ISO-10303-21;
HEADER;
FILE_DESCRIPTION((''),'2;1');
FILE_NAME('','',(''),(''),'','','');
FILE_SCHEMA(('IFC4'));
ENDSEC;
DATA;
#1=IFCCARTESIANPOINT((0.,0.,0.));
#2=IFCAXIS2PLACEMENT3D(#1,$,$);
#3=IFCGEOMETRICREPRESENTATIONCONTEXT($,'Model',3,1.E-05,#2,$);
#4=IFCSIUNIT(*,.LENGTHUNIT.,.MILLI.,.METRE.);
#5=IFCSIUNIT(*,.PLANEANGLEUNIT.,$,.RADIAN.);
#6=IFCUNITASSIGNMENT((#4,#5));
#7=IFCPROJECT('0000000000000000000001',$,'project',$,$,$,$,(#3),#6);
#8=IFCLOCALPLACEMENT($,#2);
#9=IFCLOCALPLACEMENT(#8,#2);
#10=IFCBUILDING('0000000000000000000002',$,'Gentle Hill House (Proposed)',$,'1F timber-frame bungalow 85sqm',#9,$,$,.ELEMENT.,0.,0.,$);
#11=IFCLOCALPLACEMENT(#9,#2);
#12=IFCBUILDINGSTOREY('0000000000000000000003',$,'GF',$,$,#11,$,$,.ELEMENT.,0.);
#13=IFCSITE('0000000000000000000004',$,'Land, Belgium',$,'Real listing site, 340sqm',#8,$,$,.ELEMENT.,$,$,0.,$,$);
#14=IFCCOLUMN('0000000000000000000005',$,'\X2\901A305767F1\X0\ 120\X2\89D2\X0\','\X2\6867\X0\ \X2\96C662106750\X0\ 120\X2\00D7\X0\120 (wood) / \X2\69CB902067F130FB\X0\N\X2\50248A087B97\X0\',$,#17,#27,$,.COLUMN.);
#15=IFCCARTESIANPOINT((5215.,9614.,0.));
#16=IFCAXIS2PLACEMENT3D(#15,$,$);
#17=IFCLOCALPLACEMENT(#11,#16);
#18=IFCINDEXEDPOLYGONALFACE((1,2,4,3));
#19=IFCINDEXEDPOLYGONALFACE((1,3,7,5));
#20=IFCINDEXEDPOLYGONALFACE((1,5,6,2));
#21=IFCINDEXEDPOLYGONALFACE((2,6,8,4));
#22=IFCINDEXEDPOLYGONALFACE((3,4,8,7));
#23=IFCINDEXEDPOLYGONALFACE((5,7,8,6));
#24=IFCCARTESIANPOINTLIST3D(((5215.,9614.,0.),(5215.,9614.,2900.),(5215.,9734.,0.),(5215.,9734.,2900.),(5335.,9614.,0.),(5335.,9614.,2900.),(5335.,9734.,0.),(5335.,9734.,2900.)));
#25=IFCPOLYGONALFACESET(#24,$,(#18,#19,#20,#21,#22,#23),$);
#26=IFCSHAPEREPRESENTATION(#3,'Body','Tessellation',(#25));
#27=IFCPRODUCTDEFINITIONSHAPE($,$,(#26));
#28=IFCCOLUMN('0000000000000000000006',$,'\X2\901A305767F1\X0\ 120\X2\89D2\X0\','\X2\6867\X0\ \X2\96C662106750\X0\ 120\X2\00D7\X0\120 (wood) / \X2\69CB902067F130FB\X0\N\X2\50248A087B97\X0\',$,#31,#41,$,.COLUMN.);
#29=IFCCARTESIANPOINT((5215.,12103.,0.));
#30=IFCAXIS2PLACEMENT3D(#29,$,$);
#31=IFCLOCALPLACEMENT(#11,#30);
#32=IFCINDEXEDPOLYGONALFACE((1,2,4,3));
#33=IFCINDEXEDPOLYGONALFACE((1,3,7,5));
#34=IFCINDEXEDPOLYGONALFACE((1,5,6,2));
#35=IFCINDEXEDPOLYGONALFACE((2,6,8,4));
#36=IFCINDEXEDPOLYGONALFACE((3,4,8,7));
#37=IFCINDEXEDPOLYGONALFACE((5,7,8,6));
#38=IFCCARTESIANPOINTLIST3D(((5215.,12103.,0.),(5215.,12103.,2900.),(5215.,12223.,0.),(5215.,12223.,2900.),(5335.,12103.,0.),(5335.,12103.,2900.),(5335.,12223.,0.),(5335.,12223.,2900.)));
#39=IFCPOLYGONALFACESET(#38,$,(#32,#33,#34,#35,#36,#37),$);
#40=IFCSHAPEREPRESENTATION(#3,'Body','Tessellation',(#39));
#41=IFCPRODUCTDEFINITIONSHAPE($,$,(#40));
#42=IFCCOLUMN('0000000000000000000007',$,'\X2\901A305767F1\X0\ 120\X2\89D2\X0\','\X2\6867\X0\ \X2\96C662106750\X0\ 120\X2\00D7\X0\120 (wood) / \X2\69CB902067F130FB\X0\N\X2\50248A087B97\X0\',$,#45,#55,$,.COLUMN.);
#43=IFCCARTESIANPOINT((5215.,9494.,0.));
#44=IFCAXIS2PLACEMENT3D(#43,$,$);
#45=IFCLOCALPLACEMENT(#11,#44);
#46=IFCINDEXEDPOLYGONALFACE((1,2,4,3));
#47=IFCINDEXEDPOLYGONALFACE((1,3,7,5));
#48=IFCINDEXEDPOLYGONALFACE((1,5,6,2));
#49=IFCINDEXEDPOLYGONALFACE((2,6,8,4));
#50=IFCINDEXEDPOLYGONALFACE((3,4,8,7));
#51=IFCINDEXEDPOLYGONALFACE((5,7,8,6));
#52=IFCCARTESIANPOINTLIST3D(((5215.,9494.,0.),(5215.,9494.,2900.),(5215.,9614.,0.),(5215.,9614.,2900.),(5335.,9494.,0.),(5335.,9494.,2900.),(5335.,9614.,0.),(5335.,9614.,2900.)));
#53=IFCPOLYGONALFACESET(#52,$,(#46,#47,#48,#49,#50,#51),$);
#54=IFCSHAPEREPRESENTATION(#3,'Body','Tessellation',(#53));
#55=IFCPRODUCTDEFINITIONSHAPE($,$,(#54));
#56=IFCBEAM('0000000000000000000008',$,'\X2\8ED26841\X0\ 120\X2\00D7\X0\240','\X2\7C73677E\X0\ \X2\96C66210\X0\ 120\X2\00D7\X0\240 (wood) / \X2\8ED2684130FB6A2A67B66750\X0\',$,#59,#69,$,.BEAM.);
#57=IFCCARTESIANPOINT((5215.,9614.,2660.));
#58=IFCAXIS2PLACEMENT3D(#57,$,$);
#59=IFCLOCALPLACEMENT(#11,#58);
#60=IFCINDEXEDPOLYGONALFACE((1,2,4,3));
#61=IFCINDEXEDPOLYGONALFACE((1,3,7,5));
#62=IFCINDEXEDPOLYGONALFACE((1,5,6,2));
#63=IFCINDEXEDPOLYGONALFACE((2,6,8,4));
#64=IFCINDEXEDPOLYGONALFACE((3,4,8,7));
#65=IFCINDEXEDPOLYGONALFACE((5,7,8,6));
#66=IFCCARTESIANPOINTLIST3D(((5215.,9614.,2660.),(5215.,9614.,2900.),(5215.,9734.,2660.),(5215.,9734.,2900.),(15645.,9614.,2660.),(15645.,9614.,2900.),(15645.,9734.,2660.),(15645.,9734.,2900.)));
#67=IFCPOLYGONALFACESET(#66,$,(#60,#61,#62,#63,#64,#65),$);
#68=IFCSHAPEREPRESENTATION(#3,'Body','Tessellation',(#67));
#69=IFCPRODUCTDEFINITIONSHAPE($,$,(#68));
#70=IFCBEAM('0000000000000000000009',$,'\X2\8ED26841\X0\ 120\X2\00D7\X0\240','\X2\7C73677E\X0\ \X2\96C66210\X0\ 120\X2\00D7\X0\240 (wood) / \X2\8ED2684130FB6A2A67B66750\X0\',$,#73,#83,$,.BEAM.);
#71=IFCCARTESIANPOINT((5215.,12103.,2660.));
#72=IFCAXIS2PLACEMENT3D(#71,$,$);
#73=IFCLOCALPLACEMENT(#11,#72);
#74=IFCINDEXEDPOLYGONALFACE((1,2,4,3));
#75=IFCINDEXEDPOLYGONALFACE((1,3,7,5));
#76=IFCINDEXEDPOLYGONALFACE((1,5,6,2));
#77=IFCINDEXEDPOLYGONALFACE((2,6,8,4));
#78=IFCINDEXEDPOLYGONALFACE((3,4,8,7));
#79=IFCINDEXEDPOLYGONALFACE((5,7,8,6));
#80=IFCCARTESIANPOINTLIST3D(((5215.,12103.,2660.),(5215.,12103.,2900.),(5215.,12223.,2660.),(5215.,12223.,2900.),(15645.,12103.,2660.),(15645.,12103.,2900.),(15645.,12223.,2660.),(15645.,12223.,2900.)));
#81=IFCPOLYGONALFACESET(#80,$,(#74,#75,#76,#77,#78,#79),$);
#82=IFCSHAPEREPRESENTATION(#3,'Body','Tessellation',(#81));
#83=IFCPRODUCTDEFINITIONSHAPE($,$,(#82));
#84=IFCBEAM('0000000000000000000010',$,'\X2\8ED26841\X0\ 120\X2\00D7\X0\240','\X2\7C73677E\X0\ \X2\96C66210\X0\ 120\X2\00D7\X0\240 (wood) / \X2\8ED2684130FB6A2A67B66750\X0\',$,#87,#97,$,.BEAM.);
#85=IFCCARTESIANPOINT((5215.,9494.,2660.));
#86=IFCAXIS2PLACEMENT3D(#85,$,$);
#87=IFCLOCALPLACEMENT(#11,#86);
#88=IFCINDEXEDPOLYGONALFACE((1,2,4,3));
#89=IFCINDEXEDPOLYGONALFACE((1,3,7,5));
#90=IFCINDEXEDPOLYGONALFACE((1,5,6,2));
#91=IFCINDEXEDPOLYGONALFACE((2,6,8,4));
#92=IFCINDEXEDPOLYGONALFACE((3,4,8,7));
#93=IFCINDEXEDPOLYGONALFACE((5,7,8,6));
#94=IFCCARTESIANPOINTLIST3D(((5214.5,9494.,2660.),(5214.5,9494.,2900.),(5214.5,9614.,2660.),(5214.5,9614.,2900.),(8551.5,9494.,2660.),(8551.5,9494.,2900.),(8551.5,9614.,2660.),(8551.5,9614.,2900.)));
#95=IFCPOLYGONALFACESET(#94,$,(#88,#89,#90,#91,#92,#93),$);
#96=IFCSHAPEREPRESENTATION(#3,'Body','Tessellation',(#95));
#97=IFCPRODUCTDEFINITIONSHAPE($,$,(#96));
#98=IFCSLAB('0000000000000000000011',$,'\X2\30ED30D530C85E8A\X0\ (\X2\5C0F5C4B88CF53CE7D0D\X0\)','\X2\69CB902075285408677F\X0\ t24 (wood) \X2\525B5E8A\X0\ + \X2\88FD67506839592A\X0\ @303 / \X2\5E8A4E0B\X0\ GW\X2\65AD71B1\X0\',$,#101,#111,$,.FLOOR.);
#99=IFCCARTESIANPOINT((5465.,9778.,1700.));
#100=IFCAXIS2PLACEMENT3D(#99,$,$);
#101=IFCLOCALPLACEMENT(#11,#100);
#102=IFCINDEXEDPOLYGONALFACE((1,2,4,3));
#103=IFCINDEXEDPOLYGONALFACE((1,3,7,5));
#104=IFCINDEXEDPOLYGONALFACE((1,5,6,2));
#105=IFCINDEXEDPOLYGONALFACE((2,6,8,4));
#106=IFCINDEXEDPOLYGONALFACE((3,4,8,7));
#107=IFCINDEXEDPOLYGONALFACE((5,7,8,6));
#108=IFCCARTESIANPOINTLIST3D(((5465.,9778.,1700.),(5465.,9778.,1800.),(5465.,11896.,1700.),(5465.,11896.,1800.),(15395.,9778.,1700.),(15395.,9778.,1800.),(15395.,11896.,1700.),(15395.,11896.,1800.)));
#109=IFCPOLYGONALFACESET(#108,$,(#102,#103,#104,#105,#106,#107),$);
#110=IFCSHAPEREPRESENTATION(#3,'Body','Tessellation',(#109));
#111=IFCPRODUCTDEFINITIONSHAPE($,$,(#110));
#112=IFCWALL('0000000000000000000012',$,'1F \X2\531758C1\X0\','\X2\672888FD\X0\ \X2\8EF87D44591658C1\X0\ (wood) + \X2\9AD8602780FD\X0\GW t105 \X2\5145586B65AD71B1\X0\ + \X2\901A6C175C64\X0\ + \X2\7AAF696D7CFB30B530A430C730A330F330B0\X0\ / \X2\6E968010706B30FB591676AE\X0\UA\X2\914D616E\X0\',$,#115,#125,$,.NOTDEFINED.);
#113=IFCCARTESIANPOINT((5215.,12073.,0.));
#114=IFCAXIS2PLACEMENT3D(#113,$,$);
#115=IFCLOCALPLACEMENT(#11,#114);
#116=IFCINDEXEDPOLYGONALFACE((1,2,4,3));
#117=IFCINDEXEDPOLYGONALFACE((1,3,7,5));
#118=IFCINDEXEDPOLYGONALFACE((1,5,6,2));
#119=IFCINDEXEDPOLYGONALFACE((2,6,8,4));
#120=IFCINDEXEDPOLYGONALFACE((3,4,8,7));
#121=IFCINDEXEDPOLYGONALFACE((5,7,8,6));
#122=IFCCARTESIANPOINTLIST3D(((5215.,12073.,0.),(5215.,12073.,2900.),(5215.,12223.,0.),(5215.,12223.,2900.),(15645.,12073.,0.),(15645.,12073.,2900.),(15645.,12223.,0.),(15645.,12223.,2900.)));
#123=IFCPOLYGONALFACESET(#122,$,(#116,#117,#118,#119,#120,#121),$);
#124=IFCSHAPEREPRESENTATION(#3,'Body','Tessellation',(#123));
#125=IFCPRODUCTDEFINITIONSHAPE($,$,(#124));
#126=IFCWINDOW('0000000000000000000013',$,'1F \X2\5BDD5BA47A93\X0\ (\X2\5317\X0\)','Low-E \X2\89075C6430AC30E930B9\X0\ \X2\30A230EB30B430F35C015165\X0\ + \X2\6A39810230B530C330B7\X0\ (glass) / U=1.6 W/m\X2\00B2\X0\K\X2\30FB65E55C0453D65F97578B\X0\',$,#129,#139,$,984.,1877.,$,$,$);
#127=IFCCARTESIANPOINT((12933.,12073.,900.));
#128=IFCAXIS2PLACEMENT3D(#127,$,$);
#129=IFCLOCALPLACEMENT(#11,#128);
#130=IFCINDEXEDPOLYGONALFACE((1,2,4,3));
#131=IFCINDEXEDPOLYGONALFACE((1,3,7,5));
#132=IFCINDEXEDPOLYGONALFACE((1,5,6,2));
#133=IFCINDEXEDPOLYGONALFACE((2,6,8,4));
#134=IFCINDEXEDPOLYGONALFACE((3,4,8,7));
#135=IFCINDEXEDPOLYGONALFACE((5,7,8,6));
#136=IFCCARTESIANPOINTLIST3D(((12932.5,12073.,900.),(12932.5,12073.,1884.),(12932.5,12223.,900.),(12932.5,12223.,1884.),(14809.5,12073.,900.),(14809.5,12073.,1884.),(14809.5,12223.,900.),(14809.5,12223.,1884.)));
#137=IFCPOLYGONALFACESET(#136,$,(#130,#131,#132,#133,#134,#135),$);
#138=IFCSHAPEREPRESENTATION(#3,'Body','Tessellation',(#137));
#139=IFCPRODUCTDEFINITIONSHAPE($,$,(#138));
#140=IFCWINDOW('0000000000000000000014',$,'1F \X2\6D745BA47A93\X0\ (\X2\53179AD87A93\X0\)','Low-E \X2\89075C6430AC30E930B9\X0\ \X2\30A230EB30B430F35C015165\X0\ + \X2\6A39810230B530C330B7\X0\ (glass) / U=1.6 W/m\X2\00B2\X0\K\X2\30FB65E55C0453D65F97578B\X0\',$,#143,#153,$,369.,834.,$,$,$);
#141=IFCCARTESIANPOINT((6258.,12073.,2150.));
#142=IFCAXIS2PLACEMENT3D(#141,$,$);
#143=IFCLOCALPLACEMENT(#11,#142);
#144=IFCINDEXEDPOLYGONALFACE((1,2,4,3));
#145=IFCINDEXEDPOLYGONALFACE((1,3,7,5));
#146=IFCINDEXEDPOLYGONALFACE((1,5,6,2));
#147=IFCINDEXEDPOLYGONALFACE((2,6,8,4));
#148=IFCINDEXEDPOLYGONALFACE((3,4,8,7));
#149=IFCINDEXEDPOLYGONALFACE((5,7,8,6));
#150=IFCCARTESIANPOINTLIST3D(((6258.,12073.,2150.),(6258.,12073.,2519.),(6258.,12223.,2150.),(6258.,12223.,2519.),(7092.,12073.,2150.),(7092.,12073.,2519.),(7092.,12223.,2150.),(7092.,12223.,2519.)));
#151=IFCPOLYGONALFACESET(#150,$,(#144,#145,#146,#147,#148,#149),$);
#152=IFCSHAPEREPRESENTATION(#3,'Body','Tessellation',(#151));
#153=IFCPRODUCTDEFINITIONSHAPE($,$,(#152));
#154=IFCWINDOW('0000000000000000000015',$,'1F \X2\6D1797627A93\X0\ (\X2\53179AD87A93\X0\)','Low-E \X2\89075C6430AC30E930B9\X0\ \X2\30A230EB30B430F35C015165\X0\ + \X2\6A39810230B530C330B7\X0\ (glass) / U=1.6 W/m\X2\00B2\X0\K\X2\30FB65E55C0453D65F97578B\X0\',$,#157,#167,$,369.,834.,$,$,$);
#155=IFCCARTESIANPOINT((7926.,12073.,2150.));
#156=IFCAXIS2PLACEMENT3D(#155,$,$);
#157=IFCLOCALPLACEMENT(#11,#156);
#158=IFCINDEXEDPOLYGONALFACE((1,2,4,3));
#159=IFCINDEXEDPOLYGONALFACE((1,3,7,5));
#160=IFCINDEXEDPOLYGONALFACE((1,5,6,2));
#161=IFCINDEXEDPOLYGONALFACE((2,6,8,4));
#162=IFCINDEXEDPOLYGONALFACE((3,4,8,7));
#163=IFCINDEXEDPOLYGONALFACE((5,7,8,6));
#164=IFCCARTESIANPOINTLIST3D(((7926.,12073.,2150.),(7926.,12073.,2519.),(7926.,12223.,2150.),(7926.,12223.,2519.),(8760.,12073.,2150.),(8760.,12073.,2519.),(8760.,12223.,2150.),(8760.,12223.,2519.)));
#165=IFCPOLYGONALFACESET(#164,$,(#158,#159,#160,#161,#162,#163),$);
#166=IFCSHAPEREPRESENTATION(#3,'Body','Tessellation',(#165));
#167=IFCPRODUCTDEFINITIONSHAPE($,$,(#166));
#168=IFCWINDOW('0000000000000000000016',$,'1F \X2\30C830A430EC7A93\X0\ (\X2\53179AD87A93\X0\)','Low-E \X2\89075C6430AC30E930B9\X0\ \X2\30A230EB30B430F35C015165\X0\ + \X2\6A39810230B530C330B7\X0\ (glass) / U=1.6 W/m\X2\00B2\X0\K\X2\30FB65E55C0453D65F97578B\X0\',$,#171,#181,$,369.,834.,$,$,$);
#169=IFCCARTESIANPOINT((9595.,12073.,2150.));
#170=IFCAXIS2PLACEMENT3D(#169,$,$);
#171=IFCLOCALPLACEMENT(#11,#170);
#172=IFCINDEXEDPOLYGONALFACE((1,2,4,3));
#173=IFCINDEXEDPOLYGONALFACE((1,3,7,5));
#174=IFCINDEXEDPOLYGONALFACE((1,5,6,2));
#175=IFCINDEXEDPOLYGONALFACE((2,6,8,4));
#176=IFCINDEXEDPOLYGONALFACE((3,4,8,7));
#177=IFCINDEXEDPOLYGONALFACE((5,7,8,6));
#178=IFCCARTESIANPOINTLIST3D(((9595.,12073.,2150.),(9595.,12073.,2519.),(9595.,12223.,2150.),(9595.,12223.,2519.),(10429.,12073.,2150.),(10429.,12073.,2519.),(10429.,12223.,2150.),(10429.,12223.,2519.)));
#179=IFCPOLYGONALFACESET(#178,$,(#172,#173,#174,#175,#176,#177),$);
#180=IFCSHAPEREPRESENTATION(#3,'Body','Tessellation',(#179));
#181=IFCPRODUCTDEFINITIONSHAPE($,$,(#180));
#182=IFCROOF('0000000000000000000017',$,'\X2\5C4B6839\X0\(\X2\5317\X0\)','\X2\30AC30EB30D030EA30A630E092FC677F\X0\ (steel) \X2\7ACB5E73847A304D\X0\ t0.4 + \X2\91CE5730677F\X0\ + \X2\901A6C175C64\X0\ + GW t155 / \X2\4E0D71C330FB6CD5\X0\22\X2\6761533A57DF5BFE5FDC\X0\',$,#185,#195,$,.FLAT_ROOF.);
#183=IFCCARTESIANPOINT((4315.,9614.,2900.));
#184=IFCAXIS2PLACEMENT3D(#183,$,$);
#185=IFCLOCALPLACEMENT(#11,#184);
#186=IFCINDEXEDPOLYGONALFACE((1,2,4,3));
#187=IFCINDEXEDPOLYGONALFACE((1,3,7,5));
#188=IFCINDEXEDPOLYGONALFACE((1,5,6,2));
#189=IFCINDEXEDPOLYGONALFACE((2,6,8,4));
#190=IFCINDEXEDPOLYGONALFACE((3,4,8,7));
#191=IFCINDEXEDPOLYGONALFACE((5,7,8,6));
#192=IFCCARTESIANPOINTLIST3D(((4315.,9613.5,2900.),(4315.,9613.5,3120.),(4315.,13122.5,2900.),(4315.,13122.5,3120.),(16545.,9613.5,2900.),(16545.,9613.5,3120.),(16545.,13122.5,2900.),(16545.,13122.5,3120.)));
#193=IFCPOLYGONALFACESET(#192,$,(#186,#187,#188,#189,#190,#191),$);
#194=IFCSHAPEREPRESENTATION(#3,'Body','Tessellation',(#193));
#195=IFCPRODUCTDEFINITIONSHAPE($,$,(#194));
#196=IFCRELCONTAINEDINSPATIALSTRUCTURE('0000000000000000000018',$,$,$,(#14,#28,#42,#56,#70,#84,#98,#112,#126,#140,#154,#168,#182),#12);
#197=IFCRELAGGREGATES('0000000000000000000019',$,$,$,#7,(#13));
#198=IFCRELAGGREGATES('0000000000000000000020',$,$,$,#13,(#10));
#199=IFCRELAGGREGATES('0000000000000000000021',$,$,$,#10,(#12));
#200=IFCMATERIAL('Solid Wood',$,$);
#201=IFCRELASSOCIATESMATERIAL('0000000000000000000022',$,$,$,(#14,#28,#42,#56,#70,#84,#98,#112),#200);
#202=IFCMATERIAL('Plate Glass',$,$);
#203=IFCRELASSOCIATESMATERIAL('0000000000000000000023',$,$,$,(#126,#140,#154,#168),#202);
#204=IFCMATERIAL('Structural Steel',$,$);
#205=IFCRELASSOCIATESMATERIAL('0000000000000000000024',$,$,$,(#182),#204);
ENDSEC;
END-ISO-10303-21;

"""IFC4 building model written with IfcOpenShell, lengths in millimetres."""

from ifc_helpers import new_model, si_unit, frame, frame_2d, origin, place, context, project, spatial, rectangle, extrude, material, element, fill, save


model = new_model("IFC4")

# Units and contexts
model_context = context("Model", 3, precision=1e-05, world=origin())
ifc_project = project(units=[si_unit("LENGTHUNIT", "METRE", prefix="MILLI"), si_unit("PLANEANGLEUNIT", "RADIAN")], contexts=[model_context])

# Site, building, storey
site_placement = place(None, origin())
site = spatial("IfcSite", under=ifc_project, at=site_placement, Name="Land, Belgium", ObjectType="Real listing site, 340sqm", CompositionType="ELEMENT", RefElevation=0.0)
building_placement = place(site_placement, origin())
building = spatial("IfcBuilding", under=site, at=building_placement, Name="Gentle Hill House (Proposed)", ObjectType="1F timber-frame bungalow 85sqm", CompositionType="ELEMENT", ElevationOfRefHeight=0.0, ElevationOfTerrain=0.0)
storey_placement = place(building_placement, origin())
storey = spatial("IfcBuildingStorey", under=building, at=storey_placement, Name="GF", CompositionType="ELEMENT", Elevation=0.0)

# Columns
ifc_material_1 = material(Name="Solid Wood")
column_1_placement = place(storey_placement, frame((5215.0, 9614.0, 0.0)))
element("IfcColumn", 1, at=column_1_placement, inside=storey, material=ifc_material_1, Name="通し柱 120角", Description="桧 集成材 120×120 (wood) / 構造柱・N値計算", PredefinedType="COLUMN", context=model_context, shape_type="SweptSolid", body=[
    extrude(rectangle(XDim=120.0, YDim=120.0, at=frame_2d((60.0, 60.0))), frame((5215.0, 9614.0, 0.0)), (0.0, 0.0, 1.0), 2900.0),
])
column_2_placement = place(storey_placement, frame((5215.0, 12103.0, 0.0)))
element("IfcColumn", 2, at=column_2_placement, inside=storey, material=ifc_material_1, Name="通し柱 120角", Description="桧 集成材 120×120 (wood) / 構造柱・N値計算", PredefinedType="COLUMN", context=model_context, shape_type="SweptSolid", body=[
    extrude(rectangle(XDim=120.0, YDim=120.0, at=frame_2d((60.0, 60.0))), frame((5215.0, 12103.0, 0.0)), (0.0, 0.0, 1.0), 2900.0),
])
column_3_placement = place(storey_placement, frame((5215.0, 9494.0, 0.0)))
element("IfcColumn", 3, at=column_3_placement, inside=storey, material=ifc_material_1, Name="通し柱 120角", Description="桧 集成材 120×120 (wood) / 構造柱・N値計算", PredefinedType="COLUMN", context=model_context, shape_type="SweptSolid", body=[
    extrude(rectangle(XDim=120.0, YDim=120.0, at=frame_2d((60.0, 60.0))), frame((5215.0, 9494.0, 0.0)), (0.0, 0.0, 1.0), 2900.0),
])

# Beams
beam_1_placement = place(storey_placement, frame((5215.0, 9614.0, 2660.0)))
element("IfcBeam", 4, at=beam_1_placement, inside=storey, material=ifc_material_1, Name="軒桁 120×240", Description="米松 集成 120×240 (wood) / 軒桁・横架材", PredefinedType="BEAM", context=model_context, shape_type="SweptSolid", body=[
    extrude(rectangle(XDim=10430.0, YDim=120.0, at=frame_2d((5215.0, 60.0))), frame((5215.0, 9614.0, 2660.0)), (0.0, 0.0, 1.0), 240.0),
])
beam_2_placement = place(storey_placement, frame((5215.0, 12103.0, 2660.0)))
element("IfcBeam", 5, at=beam_2_placement, inside=storey, material=ifc_material_1, Name="軒桁 120×240", Description="米松 集成 120×240 (wood) / 軒桁・横架材", PredefinedType="BEAM", context=model_context, shape_type="SweptSolid", body=[
    extrude(rectangle(XDim=10430.0, YDim=120.0, at=frame_2d((5215.0, 60.0))), frame((5215.0, 12103.0, 2660.0)), (0.0, 0.0, 1.0), 240.0),
])
beam_3_placement = place(storey_placement, frame((5215.0, 9494.0, 2660.0)))
element("IfcBeam", 6, at=beam_3_placement, inside=storey, material=ifc_material_1, Name="軒桁 120×240", Description="米松 集成 120×240 (wood) / 軒桁・横架材", PredefinedType="BEAM", context=model_context, shape_type="SweptSolid", body=[
    extrude(rectangle(XDim=3337.0, YDim=120.0, at=frame_2d((1668.0, 60.0))), frame((5215.0, 9494.0, 2660.0)), (0.0, 0.0, 1.0), 240.0),
])

# Slab
slab_1_placement = place(storey_placement, frame((5465.0, 9778.0, 1700.0)))
element("IfcSlab", 7, at=slab_1_placement, inside=storey, material=ifc_material_1, Name="ロフト床 (小屋裏収納)", Description="構造用合板 t24 (wood) 剛床 + 製材根太 @303 / 床下 GW断熱", PredefinedType="FLOOR", context=model_context, shape_type="SweptSolid", body=[
    extrude(rectangle(XDim=9930.0, YDim=2118.0, at=frame_2d((4965.0, 1059.0))), frame((5465.0, 9778.0, 1700.0)), (0.0, 0.0, 1.0), 100.0),
])

# Wall, openings, windows
wall_1_placement = place(storey_placement, frame((5215.0, 12073.0, 0.0)))
wall_1 = element("IfcWall", 8, at=wall_1_placement, inside=storey, material=ifc_material_1, Name="1F 北壁", Description="木製 軸組外壁 (wood) + 高性能GW t105 充填断熱 + 通気層 + 窯業系サイディング / 準耐火・外皮UA配慮", PredefinedType="NOTDEFINED", context=model_context, shape_type="SweptSolid", body=[
    extrude(rectangle(XDim=10430.0, YDim=150.0, at=frame_2d((5215.0, 75.0))), frame((5215.0, 12073.0, 0.0)), (0.0, 0.0, 1.0), 2900.0),
])
opening_1_placement = place(storey_placement, frame((12933.0, 12073.0, 900.0)))
opening_1 = element("IfcOpeningElement", 9, at=opening_1_placement, cuts=wall_1, PredefinedType="NOTDEFINED", context=model_context, shape_type="SweptSolid", body=[
    extrude(rectangle(XDim=1877.0, YDim=150.0, at=frame_2d((938.0, 75.0))), frame((12933.0, 12073.0, 900.0)), (0.0, 0.0, 1.0), 984.0),
])
opening_2_placement = place(storey_placement, frame((6258.0, 12073.0, 2150.0)))
opening_2 = element("IfcOpeningElement", 10, at=opening_2_placement, cuts=wall_1, PredefinedType="NOTDEFINED", context=model_context, shape_type="SweptSolid", body=[
    extrude(rectangle(XDim=834.0, YDim=150.0, at=frame_2d((417.0, 75.0))), frame((6258.0, 12073.0, 2150.0)), (0.0, 0.0, 1.0), 369.0),
])
opening_3_placement = place(storey_placement, frame((7926.0, 12073.0, 2150.0)))
opening_3 = element("IfcOpeningElement", 11, at=opening_3_placement, cuts=wall_1, PredefinedType="NOTDEFINED", context=model_context, shape_type="SweptSolid", body=[
    extrude(rectangle(XDim=834.0, YDim=150.0, at=frame_2d((417.0, 75.0))), frame((7926.0, 12073.0, 2150.0)), (0.0, 0.0, 1.0), 369.0),
])
opening_4_placement = place(storey_placement, frame((9595.0, 12073.0, 2150.0)))
opening_4 = element("IfcOpeningElement", 12, at=opening_4_placement, cuts=wall_1, PredefinedType="NOTDEFINED", context=model_context, shape_type="SweptSolid", body=[
    extrude(rectangle(XDim=834.0, YDim=150.0, at=frame_2d((417.0, 75.0))), frame((9595.0, 12073.0, 2150.0)), (0.0, 0.0, 1.0), 369.0),
])
ifc_material_2 = material(Name="Plate Glass")
window_1_placement = place(storey_placement, frame((12933.0, 12073.0, 900.0)))
window_1 = element("IfcWindow", 13, at=window_1_placement, inside=storey, material=ifc_material_2, Name="1F 寝室窓 (北)", Description="Low-E 複層ガラス アルゴン封入 + 樹脂サッシ (glass) / U=1.6 W/m²K・日射取得型", OverallHeight=984.0, OverallWidth=1877.0, context=model_context, shape_type="SweptSolid", body=[
    extrude(rectangle(XDim=1877.0, YDim=150.0, at=frame_2d((938.0, 75.0))), frame((12933.0, 12073.0, 900.0)), (0.0, 0.0, 1.0), 984.0),
])
fill(opening_1, window_1)
window_2_placement = place(storey_placement, frame((6258.0, 12073.0, 2150.0)))
window_2 = element("IfcWindow", 14, at=window_2_placement, inside=storey, material=ifc_material_2, Name="1F 浴室窓 (北高窓)", Description="Low-E 複層ガラス アルゴン封入 + 樹脂サッシ (glass) / U=1.6 W/m²K・日射取得型", OverallHeight=369.0, OverallWidth=834.0, context=model_context, shape_type="SweptSolid", body=[
    extrude(rectangle(XDim=834.0, YDim=150.0, at=frame_2d((417.0, 75.0))), frame((6258.0, 12073.0, 2150.0)), (0.0, 0.0, 1.0), 369.0),
])
fill(opening_2, window_2)
window_3_placement = place(storey_placement, frame((7926.0, 12073.0, 2150.0)))
window_3 = element("IfcWindow", 15, at=window_3_placement, inside=storey, material=ifc_material_2, Name="1F 洗面窓 (北高窓)", Description="Low-E 複層ガラス アルゴン封入 + 樹脂サッシ (glass) / U=1.6 W/m²K・日射取得型", OverallHeight=369.0, OverallWidth=834.0, context=model_context, shape_type="SweptSolid", body=[
    extrude(rectangle(XDim=834.0, YDim=150.0, at=frame_2d((417.0, 75.0))), frame((7926.0, 12073.0, 2150.0)), (0.0, 0.0, 1.0), 369.0),
])
fill(opening_3, window_3)
window_4_placement = place(storey_placement, frame((9595.0, 12073.0, 2150.0)))
window_4 = element("IfcWindow", 16, at=window_4_placement, inside=storey, material=ifc_material_2, Name="1F トイレ窓 (北高窓)", Description="Low-E 複層ガラス アルゴン封入 + 樹脂サッシ (glass) / U=1.6 W/m²K・日射取得型", OverallHeight=369.0, OverallWidth=834.0, context=model_context, shape_type="SweptSolid", body=[
    extrude(rectangle(XDim=834.0, YDim=150.0, at=frame_2d((417.0, 75.0))), frame((9595.0, 12073.0, 2150.0)), (0.0, 0.0, 1.0), 369.0),
])
fill(opening_4, window_4)

# Roof
ifc_material_3 = material(Name="Structural Steel")
roof_placement = place(storey_placement, frame((4315.0, 9614.0, 2900.0)))
element("IfcRoof", 17, at=roof_placement, inside=storey, material=ifc_material_3, Name="屋根(北)", Description="ガルバリウム鋼板 (steel) 立平葺き t0.4 + 野地板 + 通気層 + GW t155 / 不燃・法22条区域対応", PredefinedType="FLAT_ROOF", context=model_context, shape_type="SweptSolid", body=[
    extrude(rectangle(XDim=12230.0, YDim=3509.0, at=frame_2d((6115.0, 1754.0))), frame((4315.0, 9614.0, 2900.0)), (0.0, 0.0, 1.0), 220.0),
])

save(model, "model.ifc")
